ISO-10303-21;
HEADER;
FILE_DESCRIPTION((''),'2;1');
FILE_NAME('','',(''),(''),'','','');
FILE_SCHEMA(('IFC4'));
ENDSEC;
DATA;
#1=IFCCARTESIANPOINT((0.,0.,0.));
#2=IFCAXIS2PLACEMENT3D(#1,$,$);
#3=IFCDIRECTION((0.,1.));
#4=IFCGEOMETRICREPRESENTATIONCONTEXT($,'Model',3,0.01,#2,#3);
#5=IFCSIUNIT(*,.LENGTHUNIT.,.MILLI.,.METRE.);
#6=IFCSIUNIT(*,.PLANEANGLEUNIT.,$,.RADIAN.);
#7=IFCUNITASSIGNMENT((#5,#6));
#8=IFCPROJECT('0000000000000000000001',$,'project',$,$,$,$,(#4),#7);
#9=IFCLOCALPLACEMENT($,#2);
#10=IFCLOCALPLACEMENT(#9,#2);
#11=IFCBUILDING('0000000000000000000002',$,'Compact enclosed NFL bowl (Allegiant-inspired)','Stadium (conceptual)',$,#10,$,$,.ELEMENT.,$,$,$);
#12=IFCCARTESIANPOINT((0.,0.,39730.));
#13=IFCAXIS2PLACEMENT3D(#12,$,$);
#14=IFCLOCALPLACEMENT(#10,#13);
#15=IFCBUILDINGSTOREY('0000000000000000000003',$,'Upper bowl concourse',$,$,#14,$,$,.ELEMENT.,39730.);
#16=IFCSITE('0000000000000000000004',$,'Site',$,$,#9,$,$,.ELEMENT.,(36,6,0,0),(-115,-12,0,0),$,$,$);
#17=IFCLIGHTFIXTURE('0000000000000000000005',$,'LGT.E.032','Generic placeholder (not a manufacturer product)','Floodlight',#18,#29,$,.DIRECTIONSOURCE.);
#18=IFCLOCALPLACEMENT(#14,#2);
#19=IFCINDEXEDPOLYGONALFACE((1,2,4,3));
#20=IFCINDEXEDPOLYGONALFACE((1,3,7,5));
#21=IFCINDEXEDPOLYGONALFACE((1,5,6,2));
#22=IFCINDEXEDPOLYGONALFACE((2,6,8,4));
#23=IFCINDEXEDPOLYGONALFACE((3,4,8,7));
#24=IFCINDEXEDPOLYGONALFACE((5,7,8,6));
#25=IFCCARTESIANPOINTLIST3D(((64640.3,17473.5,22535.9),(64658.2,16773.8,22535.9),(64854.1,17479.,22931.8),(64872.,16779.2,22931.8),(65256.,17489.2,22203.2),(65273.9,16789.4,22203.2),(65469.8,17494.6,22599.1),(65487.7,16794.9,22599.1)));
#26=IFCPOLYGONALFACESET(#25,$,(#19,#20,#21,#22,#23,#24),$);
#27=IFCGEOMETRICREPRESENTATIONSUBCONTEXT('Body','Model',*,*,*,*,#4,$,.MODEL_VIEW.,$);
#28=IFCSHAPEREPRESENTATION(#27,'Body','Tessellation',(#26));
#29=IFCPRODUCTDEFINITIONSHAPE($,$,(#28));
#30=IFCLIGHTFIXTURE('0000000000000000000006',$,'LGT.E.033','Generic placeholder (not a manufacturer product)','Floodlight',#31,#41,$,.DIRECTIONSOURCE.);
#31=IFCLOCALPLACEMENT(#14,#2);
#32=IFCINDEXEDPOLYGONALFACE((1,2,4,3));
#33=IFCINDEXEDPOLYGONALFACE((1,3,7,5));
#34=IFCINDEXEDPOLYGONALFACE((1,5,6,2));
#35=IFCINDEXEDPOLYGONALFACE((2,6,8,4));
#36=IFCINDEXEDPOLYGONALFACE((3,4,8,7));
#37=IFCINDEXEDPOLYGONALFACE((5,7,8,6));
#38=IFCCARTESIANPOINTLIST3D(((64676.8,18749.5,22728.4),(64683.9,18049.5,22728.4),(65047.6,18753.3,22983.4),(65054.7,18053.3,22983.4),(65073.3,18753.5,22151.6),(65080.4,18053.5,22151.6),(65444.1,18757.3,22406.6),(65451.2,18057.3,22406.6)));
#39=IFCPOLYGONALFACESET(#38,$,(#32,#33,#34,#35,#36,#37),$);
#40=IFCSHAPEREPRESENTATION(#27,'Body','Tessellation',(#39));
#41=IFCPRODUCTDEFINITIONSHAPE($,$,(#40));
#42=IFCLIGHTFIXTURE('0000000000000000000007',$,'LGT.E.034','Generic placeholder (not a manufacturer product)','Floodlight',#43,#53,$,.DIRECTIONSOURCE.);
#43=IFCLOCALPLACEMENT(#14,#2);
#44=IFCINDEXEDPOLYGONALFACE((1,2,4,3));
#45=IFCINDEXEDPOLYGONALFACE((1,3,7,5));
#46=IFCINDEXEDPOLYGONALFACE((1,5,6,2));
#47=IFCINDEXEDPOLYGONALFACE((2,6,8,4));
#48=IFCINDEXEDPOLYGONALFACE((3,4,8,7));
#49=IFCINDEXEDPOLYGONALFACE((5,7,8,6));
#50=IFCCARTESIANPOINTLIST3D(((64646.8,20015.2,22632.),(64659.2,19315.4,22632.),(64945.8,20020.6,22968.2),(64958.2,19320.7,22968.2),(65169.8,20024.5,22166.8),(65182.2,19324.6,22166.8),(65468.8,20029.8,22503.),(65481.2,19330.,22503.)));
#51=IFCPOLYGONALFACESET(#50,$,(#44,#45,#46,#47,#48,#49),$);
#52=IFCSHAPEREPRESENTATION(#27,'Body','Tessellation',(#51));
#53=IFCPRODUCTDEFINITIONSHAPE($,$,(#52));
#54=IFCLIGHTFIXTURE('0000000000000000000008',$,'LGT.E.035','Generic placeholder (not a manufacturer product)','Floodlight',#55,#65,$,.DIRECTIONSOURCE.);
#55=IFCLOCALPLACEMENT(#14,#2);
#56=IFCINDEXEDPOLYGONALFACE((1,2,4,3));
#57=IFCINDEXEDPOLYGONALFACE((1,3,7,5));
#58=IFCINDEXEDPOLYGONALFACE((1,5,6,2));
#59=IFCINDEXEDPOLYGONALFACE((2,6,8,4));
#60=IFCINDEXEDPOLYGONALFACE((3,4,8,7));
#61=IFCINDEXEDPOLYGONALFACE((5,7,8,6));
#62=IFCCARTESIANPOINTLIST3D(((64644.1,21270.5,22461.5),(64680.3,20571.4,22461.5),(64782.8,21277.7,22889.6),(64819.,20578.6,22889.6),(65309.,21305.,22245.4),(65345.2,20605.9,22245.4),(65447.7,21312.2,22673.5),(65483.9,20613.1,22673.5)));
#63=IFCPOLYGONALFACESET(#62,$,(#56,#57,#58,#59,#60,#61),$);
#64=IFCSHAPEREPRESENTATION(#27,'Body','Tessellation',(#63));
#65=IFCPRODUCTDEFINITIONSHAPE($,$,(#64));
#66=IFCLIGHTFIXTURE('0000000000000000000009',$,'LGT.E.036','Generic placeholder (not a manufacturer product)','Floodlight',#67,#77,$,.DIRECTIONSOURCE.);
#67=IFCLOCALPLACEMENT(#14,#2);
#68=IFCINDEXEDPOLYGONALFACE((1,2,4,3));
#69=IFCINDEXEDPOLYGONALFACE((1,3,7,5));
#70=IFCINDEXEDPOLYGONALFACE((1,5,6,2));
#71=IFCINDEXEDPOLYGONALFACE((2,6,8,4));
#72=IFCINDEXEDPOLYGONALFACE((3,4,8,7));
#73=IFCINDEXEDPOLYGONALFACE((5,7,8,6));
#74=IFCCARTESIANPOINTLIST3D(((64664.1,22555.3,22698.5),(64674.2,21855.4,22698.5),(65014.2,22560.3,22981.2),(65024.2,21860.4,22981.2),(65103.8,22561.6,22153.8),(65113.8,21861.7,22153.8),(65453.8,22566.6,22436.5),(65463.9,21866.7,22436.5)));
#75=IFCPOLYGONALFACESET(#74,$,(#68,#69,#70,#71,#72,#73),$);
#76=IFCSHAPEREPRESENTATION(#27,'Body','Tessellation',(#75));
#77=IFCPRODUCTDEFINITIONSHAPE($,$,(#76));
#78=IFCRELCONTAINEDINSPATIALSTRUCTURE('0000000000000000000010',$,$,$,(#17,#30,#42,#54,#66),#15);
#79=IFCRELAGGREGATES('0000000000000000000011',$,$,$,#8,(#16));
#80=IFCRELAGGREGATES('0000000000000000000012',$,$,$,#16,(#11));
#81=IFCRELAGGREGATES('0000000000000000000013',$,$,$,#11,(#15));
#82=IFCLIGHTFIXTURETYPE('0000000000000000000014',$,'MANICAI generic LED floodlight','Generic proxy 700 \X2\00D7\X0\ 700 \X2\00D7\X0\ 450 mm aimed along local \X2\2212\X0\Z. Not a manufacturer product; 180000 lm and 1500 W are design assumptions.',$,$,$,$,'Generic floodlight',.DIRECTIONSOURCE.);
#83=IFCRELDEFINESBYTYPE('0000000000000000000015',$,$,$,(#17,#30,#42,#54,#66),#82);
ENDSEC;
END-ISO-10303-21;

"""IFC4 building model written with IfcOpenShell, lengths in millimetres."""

from ifc_helpers import new_model, si_unit, direction, frame, origin, place, context, subcontext, project, spatial, rectangle, extrude, source, transform, mapped, type_object, type_shapes, element, save


model = new_model("IFC4")

# Units and contexts
model_context = context("Model", 3, precision=0.01, world=origin(), true_north=direction((0.0, 1.0)))
body_context = subcontext(model_context, "Body", "Model", "MODEL_VIEW")
ifc_project = project(units=[si_unit("LENGTHUNIT", "METRE", prefix="MILLI"), si_unit("PLANEANGLEUNIT", "RADIAN")], contexts=[model_context])

# Site, building, storey
site_placement = place(None, origin())
site = spatial("IfcSite", under=ifc_project, at=site_placement, Name="Site", CompositionType="ELEMENT", RefLatitude=(36, 6, 0, 0), RefLongitude=(-115, -12, 0, 0))
building_placement = place(site_placement, origin())
building = spatial("IfcBuilding", under=site, at=building_placement, Name="Compact enclosed NFL bowl (Allegiant-inspired)", Description="Stadium (conceptual)", CompositionType="ELEMENT")
storey_placement = place(building_placement, frame((0.0, 0.0, 39730.0)))
storey = spatial("IfcBuildingStorey", under=building, at=storey_placement, Name="Upper bowl concourse", CompositionType="ELEMENT", Elevation=39730.0)

# Light fixtures
light_fixture_type = type_object("IfcLightFixtureType", Name="MANICAI generic LED floodlight", Description="Generic proxy 700 × 700 × 450 mm aimed along local −Z. Not a manufacturer product; 180000 lm and 1500 W are design assumptions.", ElementType="Generic floodlight", PredefinedType="DIRECTIONSOURCE")
shared_shape = source(origin(), body_context, "Body", "SweptSolid", [
    extrude(rectangle(XDim=700.0, YDim=700.0), frame((0.0, 0.0, -225.0)), (0.0, 0.0, 1.0), 450.0),
])
type_shapes(light_fixture_type, [shared_shape])
for number, where, z_axis, x_axis, name in (
    (1, (65064.0, 17134.2, 22567.5), (0.47509, 0.0121, 0.879854), (-0.02546, 0.999676, 0.0), "LGT.E.032"),
    (2, (65064.0, 18403.4, 22567.5), (0.823981, 0.008368, 0.566555), (-0.010155, 0.999948, 0.0), "LGT.E.033"),
    (3, (65064.0, 19672.6, 22567.5), (0.664463, 0.011798, 0.747228), (-0.017753, 0.999842, 0.0), "LGT.E.034"),
    (4, (65064.0, 20941.8, 22567.5), (0.308275, 0.015987, 0.951163), (-0.05179, 0.998658, 0.0), "LGT.E.035"),
    (5, (65064.0, 22211.0, 22567.5), (0.777995, 0.011198, 0.628171), (-0.014392, 0.999896, 0.0), "LGT.E.036"),
):
    element("IfcLightFixture", number, at=place(storey_placement, frame(where, z_axis=z_axis, x_axis=x_axis)), inside=storey, type_object=light_fixture_type, Name=name, Description="Generic placeholder (not a manufacturer product)", ObjectType="Floodlight", PredefinedType="DIRECTIONSOURCE", context=body_context, shape_type="MappedRepresentation", body=[
        mapped(shared_shape, transform((0.0, 0.0, 0.0))),
    ])

save(model, "model.ifc")
